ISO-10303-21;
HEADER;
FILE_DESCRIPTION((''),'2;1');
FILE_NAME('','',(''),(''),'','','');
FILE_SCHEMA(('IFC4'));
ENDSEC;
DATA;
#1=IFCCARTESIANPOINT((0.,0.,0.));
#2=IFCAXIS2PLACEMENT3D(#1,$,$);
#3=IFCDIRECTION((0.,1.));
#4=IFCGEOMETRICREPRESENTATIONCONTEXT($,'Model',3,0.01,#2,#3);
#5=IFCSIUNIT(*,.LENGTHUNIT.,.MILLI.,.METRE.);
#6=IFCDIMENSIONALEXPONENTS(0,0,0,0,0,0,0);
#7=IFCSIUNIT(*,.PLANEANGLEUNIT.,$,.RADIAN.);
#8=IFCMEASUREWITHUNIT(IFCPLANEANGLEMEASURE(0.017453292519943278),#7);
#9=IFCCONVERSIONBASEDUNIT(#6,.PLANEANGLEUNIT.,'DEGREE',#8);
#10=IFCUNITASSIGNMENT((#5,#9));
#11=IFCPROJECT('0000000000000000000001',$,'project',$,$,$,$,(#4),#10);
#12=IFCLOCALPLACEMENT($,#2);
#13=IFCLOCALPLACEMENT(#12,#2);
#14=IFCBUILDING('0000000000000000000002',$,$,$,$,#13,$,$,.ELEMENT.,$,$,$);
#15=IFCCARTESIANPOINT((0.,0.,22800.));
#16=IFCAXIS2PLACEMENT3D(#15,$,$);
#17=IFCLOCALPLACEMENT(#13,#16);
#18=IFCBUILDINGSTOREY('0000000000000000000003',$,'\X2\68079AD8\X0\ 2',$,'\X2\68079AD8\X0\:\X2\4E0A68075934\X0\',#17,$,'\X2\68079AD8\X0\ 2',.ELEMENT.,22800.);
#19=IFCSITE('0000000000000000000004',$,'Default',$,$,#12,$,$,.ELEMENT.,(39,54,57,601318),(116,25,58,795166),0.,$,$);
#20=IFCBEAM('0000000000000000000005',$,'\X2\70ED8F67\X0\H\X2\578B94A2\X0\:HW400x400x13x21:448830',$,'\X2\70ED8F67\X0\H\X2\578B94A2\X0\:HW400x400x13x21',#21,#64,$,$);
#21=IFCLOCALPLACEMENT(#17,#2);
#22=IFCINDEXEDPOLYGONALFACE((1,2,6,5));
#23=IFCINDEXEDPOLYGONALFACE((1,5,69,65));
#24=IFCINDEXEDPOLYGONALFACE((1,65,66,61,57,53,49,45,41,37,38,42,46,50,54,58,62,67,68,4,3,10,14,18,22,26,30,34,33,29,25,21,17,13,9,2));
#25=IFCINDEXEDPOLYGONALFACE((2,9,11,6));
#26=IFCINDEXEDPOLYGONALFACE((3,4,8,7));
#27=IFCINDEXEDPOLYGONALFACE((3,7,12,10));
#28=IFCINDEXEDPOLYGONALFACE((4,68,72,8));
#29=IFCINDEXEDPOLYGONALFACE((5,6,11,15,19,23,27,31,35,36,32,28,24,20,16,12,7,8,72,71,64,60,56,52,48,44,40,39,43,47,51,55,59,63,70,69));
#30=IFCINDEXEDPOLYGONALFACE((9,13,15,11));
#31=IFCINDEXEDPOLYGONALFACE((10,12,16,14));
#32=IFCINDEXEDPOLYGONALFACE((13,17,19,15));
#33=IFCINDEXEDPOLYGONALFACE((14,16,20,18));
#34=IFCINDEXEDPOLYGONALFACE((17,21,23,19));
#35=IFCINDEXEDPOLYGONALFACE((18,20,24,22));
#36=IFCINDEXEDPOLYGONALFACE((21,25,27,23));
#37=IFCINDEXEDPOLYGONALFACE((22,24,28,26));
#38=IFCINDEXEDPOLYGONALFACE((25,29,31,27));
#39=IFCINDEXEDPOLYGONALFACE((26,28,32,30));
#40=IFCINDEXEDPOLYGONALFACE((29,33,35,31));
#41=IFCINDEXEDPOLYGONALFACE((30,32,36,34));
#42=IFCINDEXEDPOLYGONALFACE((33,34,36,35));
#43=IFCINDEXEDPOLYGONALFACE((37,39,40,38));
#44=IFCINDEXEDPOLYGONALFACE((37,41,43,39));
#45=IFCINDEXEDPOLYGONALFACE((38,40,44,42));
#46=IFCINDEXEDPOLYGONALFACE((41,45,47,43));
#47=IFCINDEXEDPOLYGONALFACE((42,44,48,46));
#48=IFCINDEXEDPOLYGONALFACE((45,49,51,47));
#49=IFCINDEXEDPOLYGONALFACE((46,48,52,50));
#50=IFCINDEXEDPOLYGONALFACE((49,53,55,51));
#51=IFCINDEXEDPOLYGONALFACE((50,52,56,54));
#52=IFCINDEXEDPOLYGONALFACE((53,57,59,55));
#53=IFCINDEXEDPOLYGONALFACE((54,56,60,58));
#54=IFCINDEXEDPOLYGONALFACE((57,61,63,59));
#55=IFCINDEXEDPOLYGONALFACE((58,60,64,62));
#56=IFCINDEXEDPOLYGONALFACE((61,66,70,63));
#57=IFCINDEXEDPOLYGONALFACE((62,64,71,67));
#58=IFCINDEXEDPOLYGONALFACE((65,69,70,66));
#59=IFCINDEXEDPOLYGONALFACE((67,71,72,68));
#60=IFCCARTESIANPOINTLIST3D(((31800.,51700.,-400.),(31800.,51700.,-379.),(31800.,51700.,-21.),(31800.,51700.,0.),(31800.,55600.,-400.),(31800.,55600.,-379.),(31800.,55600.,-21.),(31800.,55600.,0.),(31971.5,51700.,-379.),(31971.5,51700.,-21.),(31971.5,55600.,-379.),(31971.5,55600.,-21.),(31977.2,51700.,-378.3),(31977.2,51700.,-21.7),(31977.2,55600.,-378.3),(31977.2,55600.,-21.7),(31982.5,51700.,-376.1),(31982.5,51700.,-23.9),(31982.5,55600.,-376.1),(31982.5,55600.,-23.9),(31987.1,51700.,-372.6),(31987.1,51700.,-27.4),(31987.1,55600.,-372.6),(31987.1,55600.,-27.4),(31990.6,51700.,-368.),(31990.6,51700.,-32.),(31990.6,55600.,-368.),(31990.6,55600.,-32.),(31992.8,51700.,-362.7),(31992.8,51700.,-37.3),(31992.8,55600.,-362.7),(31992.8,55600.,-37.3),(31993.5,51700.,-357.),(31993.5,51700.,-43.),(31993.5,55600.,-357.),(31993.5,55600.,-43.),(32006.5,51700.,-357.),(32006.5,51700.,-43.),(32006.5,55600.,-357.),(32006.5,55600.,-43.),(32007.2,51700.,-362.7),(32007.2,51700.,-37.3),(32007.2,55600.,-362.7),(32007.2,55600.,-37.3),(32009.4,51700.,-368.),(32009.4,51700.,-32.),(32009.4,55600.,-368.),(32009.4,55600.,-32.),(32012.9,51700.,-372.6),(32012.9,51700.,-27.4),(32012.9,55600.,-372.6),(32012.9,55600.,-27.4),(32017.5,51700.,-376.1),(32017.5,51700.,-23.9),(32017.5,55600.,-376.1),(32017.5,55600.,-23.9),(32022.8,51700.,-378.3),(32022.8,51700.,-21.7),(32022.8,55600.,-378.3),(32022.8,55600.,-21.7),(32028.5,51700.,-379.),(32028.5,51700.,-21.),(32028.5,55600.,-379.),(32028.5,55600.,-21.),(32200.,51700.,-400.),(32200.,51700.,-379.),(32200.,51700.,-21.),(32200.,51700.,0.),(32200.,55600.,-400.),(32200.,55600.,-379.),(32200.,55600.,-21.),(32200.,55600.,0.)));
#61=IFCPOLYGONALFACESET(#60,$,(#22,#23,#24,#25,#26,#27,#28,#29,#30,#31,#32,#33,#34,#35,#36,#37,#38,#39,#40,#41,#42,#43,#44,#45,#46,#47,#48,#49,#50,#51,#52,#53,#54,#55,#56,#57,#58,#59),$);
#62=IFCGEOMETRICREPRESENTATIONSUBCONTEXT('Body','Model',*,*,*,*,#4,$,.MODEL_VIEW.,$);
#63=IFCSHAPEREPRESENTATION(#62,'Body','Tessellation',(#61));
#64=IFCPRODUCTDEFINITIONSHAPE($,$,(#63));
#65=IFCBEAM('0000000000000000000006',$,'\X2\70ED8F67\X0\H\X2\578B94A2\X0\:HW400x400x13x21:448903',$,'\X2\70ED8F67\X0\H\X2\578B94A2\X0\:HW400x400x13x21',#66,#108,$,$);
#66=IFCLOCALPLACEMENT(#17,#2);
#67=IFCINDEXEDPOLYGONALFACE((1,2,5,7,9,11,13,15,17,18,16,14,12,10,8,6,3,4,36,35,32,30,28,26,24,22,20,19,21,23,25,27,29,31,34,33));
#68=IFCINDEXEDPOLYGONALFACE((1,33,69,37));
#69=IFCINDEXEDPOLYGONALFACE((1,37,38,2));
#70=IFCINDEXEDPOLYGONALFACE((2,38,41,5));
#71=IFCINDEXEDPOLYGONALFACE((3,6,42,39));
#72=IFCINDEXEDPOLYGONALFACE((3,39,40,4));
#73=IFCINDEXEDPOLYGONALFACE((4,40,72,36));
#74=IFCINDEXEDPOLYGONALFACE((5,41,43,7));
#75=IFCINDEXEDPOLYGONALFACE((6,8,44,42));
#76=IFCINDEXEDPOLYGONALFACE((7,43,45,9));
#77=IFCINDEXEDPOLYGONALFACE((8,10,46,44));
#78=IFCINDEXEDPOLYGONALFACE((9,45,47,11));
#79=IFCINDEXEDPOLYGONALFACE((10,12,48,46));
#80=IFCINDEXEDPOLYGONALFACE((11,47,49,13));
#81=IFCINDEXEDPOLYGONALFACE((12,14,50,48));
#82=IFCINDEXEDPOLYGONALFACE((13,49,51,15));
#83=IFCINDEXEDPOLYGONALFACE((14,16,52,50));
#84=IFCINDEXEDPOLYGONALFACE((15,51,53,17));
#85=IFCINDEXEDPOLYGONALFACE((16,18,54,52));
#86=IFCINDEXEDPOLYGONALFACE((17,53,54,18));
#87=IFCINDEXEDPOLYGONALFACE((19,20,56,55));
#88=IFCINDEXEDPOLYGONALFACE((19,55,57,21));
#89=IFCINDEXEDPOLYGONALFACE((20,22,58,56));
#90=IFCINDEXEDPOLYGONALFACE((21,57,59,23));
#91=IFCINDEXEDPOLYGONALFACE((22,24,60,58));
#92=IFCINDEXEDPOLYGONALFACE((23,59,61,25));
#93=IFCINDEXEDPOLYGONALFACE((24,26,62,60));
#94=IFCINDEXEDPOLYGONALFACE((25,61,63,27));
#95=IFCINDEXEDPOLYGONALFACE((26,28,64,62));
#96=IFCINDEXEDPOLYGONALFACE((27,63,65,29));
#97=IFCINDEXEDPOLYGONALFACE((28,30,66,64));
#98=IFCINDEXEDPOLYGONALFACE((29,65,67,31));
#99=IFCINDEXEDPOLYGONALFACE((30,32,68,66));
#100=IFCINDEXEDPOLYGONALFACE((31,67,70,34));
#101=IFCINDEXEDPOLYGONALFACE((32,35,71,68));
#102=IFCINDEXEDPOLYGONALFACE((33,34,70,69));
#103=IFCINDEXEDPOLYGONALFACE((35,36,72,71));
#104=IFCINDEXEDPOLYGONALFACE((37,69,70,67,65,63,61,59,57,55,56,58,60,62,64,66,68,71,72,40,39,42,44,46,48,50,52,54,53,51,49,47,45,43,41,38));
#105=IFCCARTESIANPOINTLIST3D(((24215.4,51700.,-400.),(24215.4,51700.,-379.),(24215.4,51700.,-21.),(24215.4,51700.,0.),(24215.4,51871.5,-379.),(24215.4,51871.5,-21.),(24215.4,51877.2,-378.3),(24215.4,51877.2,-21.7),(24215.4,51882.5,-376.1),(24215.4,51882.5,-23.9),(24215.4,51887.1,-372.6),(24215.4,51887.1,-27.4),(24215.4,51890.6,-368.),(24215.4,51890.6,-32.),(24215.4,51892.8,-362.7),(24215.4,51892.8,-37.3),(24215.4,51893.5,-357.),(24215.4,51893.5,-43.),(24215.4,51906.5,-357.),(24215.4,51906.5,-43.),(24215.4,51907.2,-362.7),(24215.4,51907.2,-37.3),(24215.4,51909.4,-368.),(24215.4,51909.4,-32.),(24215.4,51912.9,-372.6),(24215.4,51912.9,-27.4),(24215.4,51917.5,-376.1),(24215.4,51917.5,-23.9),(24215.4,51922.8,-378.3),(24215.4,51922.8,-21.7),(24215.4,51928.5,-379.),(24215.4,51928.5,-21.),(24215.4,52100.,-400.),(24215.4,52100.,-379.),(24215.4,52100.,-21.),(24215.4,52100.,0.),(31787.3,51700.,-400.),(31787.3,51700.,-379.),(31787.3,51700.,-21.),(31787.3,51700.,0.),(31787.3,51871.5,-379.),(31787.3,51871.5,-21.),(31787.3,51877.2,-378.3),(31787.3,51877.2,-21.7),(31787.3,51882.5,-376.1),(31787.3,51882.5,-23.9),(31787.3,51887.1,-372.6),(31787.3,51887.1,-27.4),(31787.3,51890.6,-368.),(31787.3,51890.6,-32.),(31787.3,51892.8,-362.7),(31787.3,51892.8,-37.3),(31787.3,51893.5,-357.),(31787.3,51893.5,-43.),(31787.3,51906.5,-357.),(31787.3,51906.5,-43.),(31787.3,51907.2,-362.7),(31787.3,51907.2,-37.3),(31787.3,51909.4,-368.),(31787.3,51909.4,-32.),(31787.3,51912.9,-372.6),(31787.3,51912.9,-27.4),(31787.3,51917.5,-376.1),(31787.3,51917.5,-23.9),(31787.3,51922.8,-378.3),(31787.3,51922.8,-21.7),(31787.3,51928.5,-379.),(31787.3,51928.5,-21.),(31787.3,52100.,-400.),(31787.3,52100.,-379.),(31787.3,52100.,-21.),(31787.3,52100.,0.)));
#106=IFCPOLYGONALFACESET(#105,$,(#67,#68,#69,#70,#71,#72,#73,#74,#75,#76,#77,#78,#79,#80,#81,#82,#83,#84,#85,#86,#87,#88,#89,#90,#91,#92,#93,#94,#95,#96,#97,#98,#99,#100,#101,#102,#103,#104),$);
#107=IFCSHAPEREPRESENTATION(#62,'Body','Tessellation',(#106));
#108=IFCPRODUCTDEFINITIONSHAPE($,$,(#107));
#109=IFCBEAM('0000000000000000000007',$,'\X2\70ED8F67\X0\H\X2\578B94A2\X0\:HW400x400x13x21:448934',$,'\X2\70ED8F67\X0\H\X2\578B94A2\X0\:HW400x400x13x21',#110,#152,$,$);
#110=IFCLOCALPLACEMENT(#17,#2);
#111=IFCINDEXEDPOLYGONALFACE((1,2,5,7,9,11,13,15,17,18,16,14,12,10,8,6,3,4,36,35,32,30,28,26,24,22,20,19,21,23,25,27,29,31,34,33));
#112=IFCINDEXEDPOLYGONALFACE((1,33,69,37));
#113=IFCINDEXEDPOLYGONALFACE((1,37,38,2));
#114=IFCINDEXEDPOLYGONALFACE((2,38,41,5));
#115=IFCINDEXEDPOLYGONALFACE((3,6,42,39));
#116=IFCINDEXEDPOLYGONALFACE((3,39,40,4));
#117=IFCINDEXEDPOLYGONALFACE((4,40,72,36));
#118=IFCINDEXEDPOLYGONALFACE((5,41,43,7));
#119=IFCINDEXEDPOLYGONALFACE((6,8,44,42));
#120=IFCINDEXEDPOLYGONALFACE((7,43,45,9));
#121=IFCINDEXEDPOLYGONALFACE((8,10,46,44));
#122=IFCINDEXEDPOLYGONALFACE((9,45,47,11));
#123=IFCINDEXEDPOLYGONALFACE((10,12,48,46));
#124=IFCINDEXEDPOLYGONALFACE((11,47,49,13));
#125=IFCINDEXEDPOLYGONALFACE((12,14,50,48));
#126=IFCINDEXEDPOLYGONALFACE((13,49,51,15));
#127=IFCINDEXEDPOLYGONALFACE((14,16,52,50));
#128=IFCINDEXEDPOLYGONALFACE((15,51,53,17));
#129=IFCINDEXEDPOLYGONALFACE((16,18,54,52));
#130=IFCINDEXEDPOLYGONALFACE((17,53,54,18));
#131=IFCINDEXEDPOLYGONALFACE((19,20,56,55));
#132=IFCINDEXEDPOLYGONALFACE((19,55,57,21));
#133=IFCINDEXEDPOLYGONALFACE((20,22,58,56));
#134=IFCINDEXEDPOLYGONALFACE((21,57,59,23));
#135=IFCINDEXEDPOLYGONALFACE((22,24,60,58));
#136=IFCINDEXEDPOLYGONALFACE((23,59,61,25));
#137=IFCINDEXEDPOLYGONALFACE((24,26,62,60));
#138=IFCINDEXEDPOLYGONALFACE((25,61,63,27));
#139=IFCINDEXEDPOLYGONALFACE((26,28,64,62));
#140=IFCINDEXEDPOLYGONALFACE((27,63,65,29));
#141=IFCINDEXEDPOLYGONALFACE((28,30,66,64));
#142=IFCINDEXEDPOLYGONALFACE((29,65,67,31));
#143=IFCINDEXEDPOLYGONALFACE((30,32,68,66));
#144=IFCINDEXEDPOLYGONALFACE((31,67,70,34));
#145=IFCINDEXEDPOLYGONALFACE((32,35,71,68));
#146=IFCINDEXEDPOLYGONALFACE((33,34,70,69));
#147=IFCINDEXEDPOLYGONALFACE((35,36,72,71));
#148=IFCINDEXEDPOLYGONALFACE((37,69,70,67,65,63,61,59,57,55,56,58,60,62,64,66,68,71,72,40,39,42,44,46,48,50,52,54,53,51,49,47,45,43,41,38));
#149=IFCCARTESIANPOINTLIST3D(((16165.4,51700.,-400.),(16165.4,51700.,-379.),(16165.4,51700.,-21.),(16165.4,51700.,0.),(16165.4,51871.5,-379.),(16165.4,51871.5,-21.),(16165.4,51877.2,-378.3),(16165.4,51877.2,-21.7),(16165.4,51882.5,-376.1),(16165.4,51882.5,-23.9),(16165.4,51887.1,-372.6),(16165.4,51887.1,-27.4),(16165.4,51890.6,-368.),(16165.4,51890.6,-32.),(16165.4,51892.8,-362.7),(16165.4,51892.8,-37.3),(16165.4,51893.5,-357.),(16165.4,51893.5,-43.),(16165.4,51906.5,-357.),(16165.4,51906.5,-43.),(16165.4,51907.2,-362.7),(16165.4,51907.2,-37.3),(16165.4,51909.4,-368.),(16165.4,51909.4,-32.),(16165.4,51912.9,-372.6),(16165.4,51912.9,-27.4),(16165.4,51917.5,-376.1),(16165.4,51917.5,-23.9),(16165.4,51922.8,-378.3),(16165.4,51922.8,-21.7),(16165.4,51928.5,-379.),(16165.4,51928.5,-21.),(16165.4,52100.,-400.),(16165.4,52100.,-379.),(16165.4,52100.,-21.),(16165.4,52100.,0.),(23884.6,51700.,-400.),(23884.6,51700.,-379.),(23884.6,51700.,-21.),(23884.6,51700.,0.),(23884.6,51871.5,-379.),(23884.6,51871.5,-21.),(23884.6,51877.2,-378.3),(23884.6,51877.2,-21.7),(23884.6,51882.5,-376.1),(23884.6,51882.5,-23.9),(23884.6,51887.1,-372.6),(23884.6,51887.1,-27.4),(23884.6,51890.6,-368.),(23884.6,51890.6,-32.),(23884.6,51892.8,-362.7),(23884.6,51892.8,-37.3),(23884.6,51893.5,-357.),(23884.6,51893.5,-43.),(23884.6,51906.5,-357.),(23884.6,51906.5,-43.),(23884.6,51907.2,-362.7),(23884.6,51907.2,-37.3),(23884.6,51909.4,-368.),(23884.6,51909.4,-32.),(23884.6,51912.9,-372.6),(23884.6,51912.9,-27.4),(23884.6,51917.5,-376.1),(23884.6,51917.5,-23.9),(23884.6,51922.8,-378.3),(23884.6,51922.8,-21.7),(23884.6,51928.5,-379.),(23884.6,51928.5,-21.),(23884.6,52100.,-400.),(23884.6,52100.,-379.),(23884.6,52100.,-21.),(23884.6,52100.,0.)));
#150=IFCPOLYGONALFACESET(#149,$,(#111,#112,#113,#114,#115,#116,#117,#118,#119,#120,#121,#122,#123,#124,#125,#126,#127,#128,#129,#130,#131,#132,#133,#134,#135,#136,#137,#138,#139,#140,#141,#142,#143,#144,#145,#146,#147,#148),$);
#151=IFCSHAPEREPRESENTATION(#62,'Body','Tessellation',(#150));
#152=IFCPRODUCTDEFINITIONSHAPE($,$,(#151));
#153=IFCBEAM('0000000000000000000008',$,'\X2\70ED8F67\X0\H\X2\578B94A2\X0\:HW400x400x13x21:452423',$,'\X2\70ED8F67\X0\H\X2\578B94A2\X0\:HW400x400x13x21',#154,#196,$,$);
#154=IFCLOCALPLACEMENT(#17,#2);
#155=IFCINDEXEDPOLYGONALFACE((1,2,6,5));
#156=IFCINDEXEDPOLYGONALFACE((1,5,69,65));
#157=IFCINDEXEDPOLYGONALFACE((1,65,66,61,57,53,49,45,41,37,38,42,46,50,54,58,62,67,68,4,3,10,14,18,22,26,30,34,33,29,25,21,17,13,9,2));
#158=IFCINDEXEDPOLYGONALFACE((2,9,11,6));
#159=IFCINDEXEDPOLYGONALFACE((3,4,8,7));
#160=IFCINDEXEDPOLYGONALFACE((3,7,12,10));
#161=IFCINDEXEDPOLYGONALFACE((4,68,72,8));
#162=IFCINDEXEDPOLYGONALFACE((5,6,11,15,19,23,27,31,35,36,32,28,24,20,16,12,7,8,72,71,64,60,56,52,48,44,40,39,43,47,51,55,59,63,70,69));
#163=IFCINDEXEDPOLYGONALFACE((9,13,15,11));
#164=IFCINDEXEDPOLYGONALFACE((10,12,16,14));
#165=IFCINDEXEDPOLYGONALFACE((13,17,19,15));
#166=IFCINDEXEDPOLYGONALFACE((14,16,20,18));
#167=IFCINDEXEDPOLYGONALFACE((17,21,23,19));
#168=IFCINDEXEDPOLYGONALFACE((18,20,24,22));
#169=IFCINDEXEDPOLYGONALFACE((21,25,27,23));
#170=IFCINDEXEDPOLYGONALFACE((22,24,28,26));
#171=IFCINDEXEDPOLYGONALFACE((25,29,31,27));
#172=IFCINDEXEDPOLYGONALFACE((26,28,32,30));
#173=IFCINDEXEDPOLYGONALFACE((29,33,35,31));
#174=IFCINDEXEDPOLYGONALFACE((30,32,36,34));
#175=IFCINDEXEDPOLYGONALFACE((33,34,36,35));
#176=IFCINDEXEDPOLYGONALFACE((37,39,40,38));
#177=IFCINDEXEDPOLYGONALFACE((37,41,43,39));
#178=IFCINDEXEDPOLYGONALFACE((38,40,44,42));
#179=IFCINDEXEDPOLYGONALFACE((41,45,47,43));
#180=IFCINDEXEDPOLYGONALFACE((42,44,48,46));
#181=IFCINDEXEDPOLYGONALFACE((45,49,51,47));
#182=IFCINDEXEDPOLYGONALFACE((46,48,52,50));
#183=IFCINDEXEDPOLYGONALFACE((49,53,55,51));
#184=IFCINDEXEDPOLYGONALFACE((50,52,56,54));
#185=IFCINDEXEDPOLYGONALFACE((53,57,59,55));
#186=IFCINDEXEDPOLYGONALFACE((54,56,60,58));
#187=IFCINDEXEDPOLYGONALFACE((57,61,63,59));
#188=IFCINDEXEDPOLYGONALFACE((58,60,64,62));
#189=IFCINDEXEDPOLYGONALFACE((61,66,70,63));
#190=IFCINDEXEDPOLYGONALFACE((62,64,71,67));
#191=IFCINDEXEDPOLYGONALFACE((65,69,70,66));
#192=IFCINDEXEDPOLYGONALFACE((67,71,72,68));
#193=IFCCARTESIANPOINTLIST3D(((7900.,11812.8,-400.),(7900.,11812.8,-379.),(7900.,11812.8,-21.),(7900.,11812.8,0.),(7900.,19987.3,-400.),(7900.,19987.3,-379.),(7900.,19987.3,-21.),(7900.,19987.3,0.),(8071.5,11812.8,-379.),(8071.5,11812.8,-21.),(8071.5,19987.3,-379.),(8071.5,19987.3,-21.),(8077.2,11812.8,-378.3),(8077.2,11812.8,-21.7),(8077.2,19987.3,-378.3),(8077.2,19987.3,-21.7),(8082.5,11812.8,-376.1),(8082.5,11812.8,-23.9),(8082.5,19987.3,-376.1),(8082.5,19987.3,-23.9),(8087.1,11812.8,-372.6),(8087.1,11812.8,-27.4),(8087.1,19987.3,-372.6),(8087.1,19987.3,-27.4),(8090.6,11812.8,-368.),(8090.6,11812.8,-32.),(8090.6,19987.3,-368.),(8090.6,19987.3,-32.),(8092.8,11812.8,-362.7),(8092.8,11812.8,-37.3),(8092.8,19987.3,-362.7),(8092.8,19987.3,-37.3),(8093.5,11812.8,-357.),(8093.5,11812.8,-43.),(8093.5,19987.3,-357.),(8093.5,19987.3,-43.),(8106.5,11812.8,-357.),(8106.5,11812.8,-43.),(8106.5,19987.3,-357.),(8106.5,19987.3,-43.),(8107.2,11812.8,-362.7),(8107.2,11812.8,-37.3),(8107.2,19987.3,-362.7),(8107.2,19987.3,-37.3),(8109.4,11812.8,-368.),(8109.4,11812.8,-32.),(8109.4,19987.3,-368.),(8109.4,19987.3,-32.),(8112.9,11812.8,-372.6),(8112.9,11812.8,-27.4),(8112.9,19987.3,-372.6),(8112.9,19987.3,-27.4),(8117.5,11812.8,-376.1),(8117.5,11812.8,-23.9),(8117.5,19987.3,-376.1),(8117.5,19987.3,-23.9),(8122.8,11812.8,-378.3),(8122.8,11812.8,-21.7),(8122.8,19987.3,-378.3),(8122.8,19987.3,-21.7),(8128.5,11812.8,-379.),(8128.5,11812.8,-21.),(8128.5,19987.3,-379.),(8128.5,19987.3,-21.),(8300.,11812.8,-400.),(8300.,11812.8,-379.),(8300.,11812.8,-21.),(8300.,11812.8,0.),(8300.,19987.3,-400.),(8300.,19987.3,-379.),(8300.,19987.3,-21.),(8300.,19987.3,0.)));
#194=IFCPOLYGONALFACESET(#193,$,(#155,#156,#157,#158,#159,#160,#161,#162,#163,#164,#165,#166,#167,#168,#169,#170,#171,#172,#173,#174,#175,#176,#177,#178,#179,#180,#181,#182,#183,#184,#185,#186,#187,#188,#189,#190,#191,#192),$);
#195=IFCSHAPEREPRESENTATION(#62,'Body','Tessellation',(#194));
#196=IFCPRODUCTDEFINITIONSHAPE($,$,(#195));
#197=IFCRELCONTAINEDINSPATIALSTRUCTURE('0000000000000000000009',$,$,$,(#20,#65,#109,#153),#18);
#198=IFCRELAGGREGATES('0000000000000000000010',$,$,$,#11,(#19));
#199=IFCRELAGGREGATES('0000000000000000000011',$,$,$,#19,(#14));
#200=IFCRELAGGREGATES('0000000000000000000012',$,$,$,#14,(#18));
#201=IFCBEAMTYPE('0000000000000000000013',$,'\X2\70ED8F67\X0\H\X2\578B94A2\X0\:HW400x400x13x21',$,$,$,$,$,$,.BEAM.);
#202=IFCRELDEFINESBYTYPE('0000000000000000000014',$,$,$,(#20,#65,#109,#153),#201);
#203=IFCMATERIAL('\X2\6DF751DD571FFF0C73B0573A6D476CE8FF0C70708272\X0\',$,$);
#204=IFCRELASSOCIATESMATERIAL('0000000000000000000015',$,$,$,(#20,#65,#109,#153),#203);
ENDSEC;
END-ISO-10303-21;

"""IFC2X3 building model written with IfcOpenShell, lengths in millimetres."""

from ifc_helpers import new_model, entity, si_unit, converted_unit, direction, frame, frame_2d, origin, place, context, subcontext, project, spatial, i_section, extrude, material, type_object, element, save


model = new_model("IFC2X3")

# Units and contexts
model_context = context("Model", 3, precision=0.01, world=origin(), true_north=direction((0.0, 1.0)))
body_context = subcontext(model_context, "Body", "Model", "MODEL_VIEW")
ifc_project = project(units=[si_unit("LENGTHUNIT", "METRE", prefix="MILLI"), converted_unit("PLANEANGLEUNIT", "DEGREE", entity("IfcPlaneAngleMeasure", 0.017453292519943278), si_unit("PLANEANGLEUNIT", "RADIAN"), dimensions=[0, 0, 0, 0, 0, 0, 0])], contexts=[model_context])

# Site, building, storey
site_placement = place(None, origin())
site = spatial("IfcSite", under=ifc_project, at=site_placement, Name="Default", CompositionType="ELEMENT", RefLatitude=(39, 54, 57, 601318), RefLongitude=(116, 25, 58, 795166), RefElevation=0.0)
building_placement = place(site_placement, origin())
building = spatial("IfcBuilding", under=site, at=building_placement, CompositionType="ELEMENT")
storey_placement = place(building_placement, frame((0.0, 0.0, 22800.0)))
storey = spatial("IfcBuildingStorey", under=building, at=storey_placement, Name="标高 2", ObjectType="标高:上标头", LongName="标高 2", CompositionType="ELEMENT", Elevation=22800.0)

# Beams
ifc_material = material(Name="混凝土，现场浇注，灰色")
beam_type = type_object("IfcBeamType", Name="热轧H型钢:HW400x400x13x21", PredefinedType="BEAM")
beam_1_placement = place(storey_placement, frame((32000.0, 51900.0, 0.0), z_axis=(0.0, 0.0, 1.0), x_axis=(0.0, 1.0, 0.0)))
element("IfcBeam", 1, at=beam_1_placement, inside=storey, type_object=beam_type, material=ifc_material, Name="热轧H型钢:HW400x400x13x21:448830", ObjectType="热轧H型钢:HW400x400x13x21", context=body_context, shape_type="SweptSolid", body=[
    extrude(i_section(OverallWidth=400.0, OverallDepth=400.0, WebThickness=13.0, FlangeThickness=21.0, FilletRadius=22.0, at=frame_2d((0.0, 0.0), x_axis=(0.0, 1.0))), frame((-200.0, 0.0, -200.0), z_axis=(1.0, 0.0, 0.0), x_axis=(0.0, 0.0, -1.0)), (0.0, 0.0, 1.0), 3900.0),
])
beam_2_placement = place(storey_placement, frame((24100.0, 51900.0, 0.0)))
element("IfcBeam", 2, at=beam_2_placement, inside=storey, type_object=beam_type, material=ifc_material, Name="热轧H型钢:HW400x400x13x21:448903", ObjectType="热轧H型钢:HW400x400x13x21", context=body_context, shape_type="SweptSolid", body=[
    extrude(i_section(OverallWidth=400.0, OverallDepth=400.0, WebThickness=13.0, FlangeThickness=21.0, FilletRadius=22.0, at=frame_2d((0.0, 0.0), x_axis=(0.0, 1.0))), frame((115.4, 0.0, -200.0), z_axis=(1.0, 0.0, 0.0), x_axis=(0.0, 0.0, -1.0)), (0.0, 0.0, 1.0), 7571.9),
])
beam_3_placement = place(storey_placement, frame((16000.0, 51900.0, 0.0)))
element("IfcBeam", 3, at=beam_3_placement, inside=storey, type_object=beam_type, material=ifc_material, Name="热轧H型钢:HW400x400x13x21:448934", ObjectType="热轧H型钢:HW400x400x13x21", context=body_context, shape_type="SweptSolid", body=[
    extrude(i_section(OverallWidth=400.0, OverallDepth=400.0, WebThickness=13.0, FlangeThickness=21.0, FilletRadius=22.0, at=frame_2d((0.0, 0.0), x_axis=(0.0, 1.0))), frame((165.4, 0.0, -200.0), z_axis=(1.0, 0.0, 0.0), x_axis=(0.0, 0.0, -1.0)), (0.0, 0.0, 1.0), 7719.2),
])
beam_4_placement = place(storey_placement, frame((8100.0, 20200.0, 0.0), z_axis=(0.0, 0.0, 1.0), x_axis=(0.0, -1.0, 0.0)))
element("IfcBeam", 4, at=beam_4_placement, inside=storey, type_object=beam_type, material=ifc_material, Name="热轧H型钢:HW400x400x13x21:452423", ObjectType="热轧H型钢:HW400x400x13x21", context=body_context, shape_type="SweptSolid", body=[
    extrude(i_section(OverallWidth=400.0, OverallDepth=400.0, WebThickness=13.0, FlangeThickness=21.0, FilletRadius=22.0, at=frame_2d((0.0, 0.0), x_axis=(0.0, 1.0))), frame((212.7, 0.0, -200.0), z_axis=(1.0, 0.0, 0.0), x_axis=(0.0, 0.0, -1.0)), (0.0, 0.0, 1.0), 8174.5),
])

save(model, "model.ifc")
